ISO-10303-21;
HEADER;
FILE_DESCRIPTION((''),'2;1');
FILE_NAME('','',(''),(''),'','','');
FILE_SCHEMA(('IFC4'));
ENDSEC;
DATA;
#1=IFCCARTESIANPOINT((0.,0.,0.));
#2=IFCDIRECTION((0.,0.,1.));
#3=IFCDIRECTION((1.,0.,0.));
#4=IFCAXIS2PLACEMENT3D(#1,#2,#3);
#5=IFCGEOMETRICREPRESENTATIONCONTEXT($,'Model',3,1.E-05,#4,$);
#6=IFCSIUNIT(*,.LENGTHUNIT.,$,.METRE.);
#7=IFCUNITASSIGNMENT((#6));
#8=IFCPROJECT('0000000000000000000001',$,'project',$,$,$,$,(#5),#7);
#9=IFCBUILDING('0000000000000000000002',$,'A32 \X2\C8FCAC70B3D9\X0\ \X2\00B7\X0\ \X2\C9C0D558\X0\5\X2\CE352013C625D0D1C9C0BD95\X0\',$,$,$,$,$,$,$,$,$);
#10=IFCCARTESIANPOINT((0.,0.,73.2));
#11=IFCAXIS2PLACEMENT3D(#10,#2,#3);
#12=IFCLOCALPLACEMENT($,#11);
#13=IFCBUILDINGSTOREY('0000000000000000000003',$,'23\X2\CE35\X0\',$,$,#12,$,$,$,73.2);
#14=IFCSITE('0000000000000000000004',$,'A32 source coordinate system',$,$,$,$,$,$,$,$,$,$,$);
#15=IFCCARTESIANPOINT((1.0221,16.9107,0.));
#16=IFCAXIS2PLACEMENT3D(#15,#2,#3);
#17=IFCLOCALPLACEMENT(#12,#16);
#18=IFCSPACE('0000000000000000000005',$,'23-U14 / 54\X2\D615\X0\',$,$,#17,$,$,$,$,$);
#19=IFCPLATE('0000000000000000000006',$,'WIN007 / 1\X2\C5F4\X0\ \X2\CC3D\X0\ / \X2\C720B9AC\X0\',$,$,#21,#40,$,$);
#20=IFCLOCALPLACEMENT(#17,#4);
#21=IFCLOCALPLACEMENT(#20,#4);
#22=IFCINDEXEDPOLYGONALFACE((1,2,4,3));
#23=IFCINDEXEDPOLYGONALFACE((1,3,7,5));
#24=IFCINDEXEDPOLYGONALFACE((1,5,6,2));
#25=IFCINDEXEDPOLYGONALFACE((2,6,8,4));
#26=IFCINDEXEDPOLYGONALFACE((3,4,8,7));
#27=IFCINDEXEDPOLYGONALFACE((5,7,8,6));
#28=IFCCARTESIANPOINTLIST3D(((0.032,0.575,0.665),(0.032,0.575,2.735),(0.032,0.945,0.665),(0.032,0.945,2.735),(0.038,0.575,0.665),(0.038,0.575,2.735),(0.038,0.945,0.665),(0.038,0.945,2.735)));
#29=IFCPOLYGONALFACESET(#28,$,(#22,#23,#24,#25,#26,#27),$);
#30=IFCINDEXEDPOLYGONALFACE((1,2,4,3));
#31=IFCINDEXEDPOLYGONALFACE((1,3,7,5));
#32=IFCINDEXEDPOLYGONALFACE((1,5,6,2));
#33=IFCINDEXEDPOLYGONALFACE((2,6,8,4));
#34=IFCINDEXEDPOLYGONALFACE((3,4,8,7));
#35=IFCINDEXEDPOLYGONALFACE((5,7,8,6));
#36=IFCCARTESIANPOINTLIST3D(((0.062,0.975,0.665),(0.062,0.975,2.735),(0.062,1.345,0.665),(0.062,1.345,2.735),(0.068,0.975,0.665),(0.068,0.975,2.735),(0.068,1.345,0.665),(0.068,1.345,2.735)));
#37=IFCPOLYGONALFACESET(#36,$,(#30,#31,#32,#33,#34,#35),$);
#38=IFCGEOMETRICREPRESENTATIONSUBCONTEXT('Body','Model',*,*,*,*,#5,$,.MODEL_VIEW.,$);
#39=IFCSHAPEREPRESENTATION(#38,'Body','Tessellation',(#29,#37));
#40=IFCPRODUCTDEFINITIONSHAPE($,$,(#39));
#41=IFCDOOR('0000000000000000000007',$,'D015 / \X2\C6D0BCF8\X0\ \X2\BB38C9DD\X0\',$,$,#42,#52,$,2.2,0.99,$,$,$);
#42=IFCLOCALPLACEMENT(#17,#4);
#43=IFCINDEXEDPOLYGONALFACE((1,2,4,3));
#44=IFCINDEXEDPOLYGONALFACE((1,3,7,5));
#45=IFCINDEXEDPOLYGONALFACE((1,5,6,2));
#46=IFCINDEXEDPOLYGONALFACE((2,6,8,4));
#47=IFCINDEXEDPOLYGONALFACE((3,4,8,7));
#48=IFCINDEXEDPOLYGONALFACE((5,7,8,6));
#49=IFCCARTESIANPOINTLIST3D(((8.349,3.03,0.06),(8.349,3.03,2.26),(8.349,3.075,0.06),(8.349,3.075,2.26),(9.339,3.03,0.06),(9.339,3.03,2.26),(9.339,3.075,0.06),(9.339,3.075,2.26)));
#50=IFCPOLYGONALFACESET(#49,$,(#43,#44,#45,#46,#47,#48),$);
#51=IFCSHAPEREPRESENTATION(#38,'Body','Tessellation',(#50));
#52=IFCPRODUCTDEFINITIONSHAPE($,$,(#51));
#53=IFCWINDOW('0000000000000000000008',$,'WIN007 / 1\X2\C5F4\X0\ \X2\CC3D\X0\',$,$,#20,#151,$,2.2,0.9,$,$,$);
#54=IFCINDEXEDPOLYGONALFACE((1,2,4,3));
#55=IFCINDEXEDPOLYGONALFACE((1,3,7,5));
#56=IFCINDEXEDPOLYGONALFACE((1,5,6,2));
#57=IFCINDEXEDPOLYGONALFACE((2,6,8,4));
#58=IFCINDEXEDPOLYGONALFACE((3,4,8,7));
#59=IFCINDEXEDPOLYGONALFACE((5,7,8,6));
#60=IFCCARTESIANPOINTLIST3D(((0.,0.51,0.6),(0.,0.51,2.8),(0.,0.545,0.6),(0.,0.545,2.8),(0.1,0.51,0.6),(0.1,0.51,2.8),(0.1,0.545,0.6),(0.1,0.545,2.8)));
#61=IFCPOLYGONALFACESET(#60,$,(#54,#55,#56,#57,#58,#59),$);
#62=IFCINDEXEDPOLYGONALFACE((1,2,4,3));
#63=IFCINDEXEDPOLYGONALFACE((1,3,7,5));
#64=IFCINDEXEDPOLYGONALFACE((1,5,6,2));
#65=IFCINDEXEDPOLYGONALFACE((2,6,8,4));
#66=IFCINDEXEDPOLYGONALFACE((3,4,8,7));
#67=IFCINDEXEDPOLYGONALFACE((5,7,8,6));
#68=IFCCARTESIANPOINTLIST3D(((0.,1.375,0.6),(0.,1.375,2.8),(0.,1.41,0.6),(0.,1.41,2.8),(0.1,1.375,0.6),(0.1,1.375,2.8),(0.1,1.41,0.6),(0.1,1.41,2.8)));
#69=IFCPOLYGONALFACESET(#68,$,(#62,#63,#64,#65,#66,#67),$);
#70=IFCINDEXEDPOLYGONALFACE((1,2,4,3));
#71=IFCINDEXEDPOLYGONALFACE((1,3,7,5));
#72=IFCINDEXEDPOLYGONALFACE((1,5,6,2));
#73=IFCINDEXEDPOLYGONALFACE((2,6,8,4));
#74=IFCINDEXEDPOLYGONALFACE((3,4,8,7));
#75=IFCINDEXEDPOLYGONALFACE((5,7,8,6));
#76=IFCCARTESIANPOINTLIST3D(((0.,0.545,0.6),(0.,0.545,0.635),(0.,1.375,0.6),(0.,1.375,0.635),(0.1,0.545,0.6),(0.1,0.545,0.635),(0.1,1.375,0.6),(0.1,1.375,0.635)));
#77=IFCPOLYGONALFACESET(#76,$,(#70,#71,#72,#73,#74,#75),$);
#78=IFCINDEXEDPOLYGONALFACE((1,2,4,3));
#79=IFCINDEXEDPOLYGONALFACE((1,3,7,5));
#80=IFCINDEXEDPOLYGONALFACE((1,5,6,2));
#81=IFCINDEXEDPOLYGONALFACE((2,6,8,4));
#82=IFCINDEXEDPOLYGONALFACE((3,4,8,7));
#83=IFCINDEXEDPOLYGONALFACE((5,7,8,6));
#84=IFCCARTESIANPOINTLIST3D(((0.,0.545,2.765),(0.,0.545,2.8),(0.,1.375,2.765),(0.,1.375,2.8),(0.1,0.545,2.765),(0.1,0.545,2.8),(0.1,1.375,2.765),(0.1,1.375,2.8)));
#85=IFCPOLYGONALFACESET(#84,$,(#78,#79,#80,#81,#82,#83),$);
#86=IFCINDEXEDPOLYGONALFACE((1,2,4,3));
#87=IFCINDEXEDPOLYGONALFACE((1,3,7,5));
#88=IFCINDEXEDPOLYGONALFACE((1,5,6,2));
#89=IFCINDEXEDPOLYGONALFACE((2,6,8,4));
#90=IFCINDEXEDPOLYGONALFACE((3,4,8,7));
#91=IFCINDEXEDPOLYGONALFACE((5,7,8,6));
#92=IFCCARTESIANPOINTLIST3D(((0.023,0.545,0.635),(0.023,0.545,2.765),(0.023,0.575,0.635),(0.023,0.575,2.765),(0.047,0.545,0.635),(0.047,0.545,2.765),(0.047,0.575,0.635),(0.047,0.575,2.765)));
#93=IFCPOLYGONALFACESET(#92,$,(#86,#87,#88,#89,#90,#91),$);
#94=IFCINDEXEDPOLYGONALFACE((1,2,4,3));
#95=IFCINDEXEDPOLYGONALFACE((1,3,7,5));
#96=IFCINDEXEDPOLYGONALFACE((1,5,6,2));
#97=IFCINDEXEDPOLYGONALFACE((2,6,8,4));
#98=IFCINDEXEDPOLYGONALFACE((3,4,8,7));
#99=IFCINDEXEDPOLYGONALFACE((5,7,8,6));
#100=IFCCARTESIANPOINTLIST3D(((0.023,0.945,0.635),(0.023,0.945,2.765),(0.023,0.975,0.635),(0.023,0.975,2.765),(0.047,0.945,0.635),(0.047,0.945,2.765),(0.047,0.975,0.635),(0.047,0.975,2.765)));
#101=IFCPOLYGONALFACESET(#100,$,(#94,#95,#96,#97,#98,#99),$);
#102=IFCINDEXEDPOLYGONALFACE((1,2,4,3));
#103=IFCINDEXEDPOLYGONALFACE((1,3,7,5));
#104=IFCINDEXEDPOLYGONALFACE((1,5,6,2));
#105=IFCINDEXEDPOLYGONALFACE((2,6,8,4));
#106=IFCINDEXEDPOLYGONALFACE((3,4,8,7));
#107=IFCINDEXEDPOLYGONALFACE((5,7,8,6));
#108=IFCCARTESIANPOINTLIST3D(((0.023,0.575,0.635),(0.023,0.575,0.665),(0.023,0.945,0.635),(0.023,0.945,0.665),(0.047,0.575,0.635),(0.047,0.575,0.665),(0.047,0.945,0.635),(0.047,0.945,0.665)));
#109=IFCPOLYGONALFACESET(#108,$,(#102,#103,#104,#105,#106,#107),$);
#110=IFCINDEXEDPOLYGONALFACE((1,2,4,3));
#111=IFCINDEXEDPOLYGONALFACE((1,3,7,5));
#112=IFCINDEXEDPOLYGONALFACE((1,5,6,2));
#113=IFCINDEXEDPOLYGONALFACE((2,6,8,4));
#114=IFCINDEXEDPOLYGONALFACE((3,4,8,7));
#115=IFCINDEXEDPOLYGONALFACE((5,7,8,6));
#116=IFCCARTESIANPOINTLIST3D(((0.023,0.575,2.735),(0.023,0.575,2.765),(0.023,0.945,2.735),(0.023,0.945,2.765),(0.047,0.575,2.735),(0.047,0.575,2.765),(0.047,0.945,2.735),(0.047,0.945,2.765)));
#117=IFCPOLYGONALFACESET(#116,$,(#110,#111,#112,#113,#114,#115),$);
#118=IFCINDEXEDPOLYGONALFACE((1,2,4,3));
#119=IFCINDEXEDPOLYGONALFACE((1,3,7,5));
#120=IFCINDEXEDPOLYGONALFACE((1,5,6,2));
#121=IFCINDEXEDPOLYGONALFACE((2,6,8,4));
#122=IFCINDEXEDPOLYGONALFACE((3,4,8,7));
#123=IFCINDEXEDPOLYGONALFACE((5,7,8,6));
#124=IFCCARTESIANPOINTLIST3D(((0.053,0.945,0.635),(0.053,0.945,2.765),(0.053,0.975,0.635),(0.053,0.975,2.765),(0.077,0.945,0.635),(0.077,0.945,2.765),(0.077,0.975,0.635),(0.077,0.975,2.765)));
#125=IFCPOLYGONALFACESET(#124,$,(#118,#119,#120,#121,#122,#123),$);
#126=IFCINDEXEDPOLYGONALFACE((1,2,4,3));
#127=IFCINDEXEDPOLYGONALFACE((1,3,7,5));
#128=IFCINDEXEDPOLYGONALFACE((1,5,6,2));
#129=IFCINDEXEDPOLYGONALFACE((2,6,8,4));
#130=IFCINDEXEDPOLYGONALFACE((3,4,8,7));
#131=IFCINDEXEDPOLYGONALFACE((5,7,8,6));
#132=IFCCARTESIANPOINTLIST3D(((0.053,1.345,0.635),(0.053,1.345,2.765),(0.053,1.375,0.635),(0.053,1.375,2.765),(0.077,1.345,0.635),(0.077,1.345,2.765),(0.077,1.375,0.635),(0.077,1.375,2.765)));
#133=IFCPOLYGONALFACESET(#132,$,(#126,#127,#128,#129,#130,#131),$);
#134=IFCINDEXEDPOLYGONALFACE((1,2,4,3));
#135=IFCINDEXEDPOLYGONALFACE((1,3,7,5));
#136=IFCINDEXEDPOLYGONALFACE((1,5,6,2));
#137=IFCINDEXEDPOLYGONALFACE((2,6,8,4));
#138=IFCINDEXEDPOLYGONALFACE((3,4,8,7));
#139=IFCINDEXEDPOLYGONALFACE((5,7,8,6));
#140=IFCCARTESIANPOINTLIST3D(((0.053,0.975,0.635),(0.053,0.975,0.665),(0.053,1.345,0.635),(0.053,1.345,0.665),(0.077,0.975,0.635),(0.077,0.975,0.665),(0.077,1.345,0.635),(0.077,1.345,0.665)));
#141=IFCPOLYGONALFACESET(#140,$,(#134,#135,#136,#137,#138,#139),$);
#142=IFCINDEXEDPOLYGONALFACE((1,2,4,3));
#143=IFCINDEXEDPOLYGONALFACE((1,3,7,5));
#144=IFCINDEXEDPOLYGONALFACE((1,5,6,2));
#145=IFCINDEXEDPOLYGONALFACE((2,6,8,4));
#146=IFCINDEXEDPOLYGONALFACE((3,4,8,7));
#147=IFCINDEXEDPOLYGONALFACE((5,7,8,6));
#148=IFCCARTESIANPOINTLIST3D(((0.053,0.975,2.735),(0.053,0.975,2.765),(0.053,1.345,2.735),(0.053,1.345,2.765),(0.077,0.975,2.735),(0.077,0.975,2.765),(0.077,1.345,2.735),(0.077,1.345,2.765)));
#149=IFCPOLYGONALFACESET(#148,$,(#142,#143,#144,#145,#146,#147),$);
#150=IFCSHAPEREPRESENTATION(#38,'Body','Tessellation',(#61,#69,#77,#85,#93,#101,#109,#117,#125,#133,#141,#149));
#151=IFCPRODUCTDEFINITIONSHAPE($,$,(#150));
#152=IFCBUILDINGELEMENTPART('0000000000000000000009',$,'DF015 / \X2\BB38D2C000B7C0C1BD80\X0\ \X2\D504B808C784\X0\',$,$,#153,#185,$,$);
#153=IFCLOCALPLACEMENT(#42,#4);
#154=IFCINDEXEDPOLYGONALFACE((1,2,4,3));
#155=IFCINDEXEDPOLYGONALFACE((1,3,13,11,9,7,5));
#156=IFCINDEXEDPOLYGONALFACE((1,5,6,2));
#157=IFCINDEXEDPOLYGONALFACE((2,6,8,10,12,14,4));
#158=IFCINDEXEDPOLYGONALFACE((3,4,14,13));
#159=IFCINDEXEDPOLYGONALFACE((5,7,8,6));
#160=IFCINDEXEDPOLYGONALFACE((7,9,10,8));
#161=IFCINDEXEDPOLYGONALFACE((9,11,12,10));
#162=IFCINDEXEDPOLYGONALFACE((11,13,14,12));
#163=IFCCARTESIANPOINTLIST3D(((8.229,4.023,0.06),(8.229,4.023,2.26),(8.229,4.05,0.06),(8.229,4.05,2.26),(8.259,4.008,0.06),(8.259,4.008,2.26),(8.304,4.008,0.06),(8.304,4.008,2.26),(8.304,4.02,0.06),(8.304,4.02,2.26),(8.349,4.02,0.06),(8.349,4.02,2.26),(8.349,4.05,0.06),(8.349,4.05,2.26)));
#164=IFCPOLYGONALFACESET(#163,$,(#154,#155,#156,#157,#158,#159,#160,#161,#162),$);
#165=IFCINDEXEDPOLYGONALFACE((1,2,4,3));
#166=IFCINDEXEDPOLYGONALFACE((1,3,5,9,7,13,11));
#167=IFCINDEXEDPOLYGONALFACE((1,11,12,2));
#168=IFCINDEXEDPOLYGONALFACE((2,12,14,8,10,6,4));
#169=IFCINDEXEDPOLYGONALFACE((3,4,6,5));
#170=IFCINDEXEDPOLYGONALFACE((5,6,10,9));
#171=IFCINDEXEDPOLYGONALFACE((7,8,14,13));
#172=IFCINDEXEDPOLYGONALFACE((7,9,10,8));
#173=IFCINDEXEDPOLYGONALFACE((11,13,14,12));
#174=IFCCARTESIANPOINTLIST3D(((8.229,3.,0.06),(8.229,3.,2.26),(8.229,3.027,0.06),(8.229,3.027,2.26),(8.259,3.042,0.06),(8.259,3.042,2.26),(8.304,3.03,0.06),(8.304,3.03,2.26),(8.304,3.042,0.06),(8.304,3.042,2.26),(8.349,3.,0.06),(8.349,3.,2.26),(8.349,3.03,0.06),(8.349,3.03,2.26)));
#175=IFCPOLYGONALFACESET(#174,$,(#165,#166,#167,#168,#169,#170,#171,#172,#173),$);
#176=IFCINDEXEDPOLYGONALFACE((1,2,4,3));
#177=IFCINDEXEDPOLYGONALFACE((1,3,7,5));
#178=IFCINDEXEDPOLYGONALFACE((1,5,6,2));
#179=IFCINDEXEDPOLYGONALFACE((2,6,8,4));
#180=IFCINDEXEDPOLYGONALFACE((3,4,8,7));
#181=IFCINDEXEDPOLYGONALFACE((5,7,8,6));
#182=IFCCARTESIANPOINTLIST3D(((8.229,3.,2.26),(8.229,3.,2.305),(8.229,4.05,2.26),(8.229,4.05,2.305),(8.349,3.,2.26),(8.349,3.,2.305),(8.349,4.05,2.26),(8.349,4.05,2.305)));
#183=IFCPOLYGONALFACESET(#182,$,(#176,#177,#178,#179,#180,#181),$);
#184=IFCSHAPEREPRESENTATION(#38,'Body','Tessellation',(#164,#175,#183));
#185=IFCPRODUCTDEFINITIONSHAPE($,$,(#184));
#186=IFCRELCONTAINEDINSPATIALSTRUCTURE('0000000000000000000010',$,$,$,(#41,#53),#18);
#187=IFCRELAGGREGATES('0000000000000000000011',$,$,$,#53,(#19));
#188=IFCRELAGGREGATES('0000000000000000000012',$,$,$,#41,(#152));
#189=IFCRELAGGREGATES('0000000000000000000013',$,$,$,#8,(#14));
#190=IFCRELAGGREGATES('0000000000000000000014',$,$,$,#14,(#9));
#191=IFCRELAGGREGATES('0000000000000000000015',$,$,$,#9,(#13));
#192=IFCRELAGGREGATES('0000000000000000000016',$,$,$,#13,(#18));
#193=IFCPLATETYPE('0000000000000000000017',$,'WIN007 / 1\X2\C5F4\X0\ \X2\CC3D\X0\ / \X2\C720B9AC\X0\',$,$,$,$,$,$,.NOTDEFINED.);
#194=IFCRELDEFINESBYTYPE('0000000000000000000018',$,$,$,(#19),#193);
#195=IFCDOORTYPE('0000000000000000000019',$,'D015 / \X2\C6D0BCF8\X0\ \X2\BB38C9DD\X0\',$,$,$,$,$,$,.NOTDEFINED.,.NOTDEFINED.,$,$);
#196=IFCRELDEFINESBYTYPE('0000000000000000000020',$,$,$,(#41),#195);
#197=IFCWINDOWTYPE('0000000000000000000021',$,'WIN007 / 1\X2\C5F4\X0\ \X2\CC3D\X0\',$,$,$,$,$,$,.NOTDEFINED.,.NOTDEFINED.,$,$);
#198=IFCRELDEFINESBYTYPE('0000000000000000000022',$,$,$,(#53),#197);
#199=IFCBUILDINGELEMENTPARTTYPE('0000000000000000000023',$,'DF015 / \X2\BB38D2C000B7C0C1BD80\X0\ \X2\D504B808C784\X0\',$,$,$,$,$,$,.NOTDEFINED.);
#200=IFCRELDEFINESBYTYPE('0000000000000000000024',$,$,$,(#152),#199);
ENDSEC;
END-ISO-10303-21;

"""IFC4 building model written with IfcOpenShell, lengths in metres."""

from ifc_helpers import new_model, si_unit, frame, origin, origin_with_axes, place, context, subcontext, project, spatial, polyline, outline, extrude, source, transform, mapped, type_object, type_shapes, element, aggregate, save


model = new_model("IFC4")

# Units and contexts
model_context = context("Model", 3, precision=1e-05, world=origin_with_axes())
body_context = subcontext(model_context, "Body", "Model", "MODEL_VIEW")
ifc_project = project(units=[si_unit("LENGTHUNIT", "METRE")], contexts=[model_context])

# Plate
plate_type_1 = type_object("IfcPlateType", Name="WIN007 / 1열 창 / 유리", PredefinedType="NOTDEFINED")
shared_shape_1 = source(origin(), body_context, "Body", "SweptSolid", [
    extrude(outline(polyline([(0.032, 0.575), (0.032, 0.945), (0.038, 0.945), (0.038, 0.575), (0.032, 0.575)])), frame((0.0, 0.0, 0.665)), (0.0, 0.0, 1.0), 2.07),
    extrude(outline(polyline([(0.062, 0.975), (0.062, 1.345), (0.068, 1.345), (0.068, 0.975), (0.062, 0.975)])), frame((0.0, 0.0, 0.665)), (0.0, 0.0, 1.0), 2.07),
])
type_shapes(plate_type_1, [shared_shape_1])
storey_placement = place(None, frame((0.0, 0.0, 73.2), z_axis=(0.0, 0.0, 1.0), x_axis=(1.0, 0.0, 0.0)))
space_placement = place(storey_placement, frame((1.0221, 16.9107, 0.0), z_axis=(0.0, 0.0, 1.0), x_axis=(1.0, 0.0, 0.0)))
window_1_placement = place(space_placement, origin_with_axes())
plate_1_placement = place(window_1_placement, origin_with_axes())
plate_1 = element("IfcPlate", 1, at=plate_1_placement, type_object=plate_type_1, Name="WIN007 / 1열 창 / 유리", context=body_context, shape_type="MappedRepresentation", body=[
    mapped(shared_shape_1, transform((0.0, 0.0, 0.0), scale=1.0)),
])

# Site, building, storey, space
site = spatial("IfcSite", under=ifc_project, Name="A32 source coordinate system")
building = spatial("IfcBuilding", under=site, Name="A32 주거동 · 지하5층–옥탑지붕")
storey = spatial("IfcBuildingStorey", under=building, at=storey_placement, Name="23층", Elevation=73.2)
space = spatial("IfcSpace", under=storey, at=space_placement, Name="23-U14 / 54형")

# Door
door_type_1 = type_object("IfcDoorType", Name="D015 / 원본 문짝", OperationType="NOTDEFINED", PredefinedType="NOTDEFINED")
shared_shape_2 = source(origin(), body_context, "Body", "SweptSolid", [
    extrude(outline(polyline([(9.339, 3.075), (9.339, 3.03), (8.349, 3.03), (8.349, 3.075), (9.339, 3.075)])), frame((0.0, 0.0, 0.06)), (0.0, 0.0, 1.0), 2.2),
])
type_shapes(door_type_1, [shared_shape_2])
door_1_placement = place(space_placement, origin_with_axes())
door_1 = element("IfcDoor", 2, at=door_1_placement, inside=space, type_object=door_type_1, Name="D015 / 원본 문짝", OverallHeight=2.2, OverallWidth=0.99, context=body_context, shape_type="MappedRepresentation", body=[
    mapped(shared_shape_2, transform((0.0, 0.0, 0.0), scale=1.0)),
])

# Window
window_type_1 = type_object("IfcWindowType", Name="WIN007 / 1열 창", PartitioningType="NOTDEFINED", PredefinedType="NOTDEFINED")
shared_shape_3 = source(origin(), body_context, "Body", "SweptSolid", [
    extrude(outline(polyline([(0.0, 0.51), (0.0, 0.545), (0.1, 0.545), (0.1, 0.51), (0.0, 0.51)])), frame((0.0, 0.0, 0.6)), (0.0, 0.0, 1.0), 2.2),
    extrude(outline(polyline([(0.0, 1.375), (0.0, 1.41), (0.1, 1.41), (0.1, 1.375), (0.0, 1.375)])), frame((0.0, 0.0, 0.6)), (0.0, 0.0, 1.0), 2.2),
    extrude(outline(polyline([(0.0, 0.545), (0.0, 1.375), (0.1, 1.375), (0.1, 0.545), (0.0, 0.545)])), frame((0.0, 0.0, 0.6)), (0.0, 0.0, 1.0), 0.035),
    extrude(outline(polyline([(0.0, 0.545), (0.0, 1.375), (0.1, 1.375), (0.1, 0.545), (0.0, 0.545)])), frame((0.0, 0.0, 2.765)), (0.0, 0.0, 1.0), 0.035),
    extrude(outline(polyline([(0.023, 0.545), (0.023, 0.575), (0.047, 0.575), (0.047, 0.545), (0.023, 0.545)])), frame((0.0, 0.0, 0.635)), (0.0, 0.0, 1.0), 2.13),
    extrude(outline(polyline([(0.023, 0.945), (0.023, 0.975), (0.047, 0.975), (0.047, 0.945), (0.023, 0.945)])), frame((0.0, 0.0, 0.635)), (0.0, 0.0, 1.0), 2.13),
    extrude(outline(polyline([(0.023, 0.575), (0.023, 0.945), (0.047, 0.945), (0.047, 0.575), (0.023, 0.575)])), frame((0.0, 0.0, 0.635)), (0.0, 0.0, 1.0), 0.03),
    extrude(outline(polyline([(0.023, 0.575), (0.023, 0.945), (0.047, 0.945), (0.047, 0.575), (0.023, 0.575)])), frame((0.0, 0.0, 2.735)), (0.0, 0.0, 1.0), 0.03),
    extrude(outline(polyline([(0.053, 0.945), (0.053, 0.975), (0.077, 0.975), (0.077, 0.945), (0.053, 0.945)])), frame((0.0, 0.0, 0.635)), (0.0, 0.0, 1.0), 2.13),
    extrude(outline(polyline([(0.053, 1.345), (0.053, 1.375), (0.077, 1.375), (0.077, 1.345), (0.053, 1.345)])), frame((0.0, 0.0, 0.635)), (0.0, 0.0, 1.0), 2.13),
    extrude(outline(polyline([(0.053, 0.975), (0.053, 1.345), (0.077, 1.345), (0.077, 0.975), (0.053, 0.975)])), frame((0.0, 0.0, 0.635)), (0.0, 0.0, 1.0), 0.03),
    extrude(outline(polyline([(0.053, 0.975), (0.053, 1.345), (0.077, 1.345), (0.077, 0.975), (0.053, 0.975)])), frame((0.0, 0.0, 2.735)), (0.0, 0.0, 1.0), 0.03),
])
type_shapes(window_type_1, [shared_shape_3])
window_1 = element("IfcWindow", 3, at=window_1_placement, inside=space, type_object=window_type_1, Name="WIN007 / 1열 창", OverallHeight=2.2, OverallWidth=0.9, context=body_context, shape_type="MappedRepresentation", body=[
    mapped(shared_shape_3, transform((0.0, 0.0, 0.0), scale=1.0)),
])
aggregate(window_1, [plate_1])

# Building element part
building_element_part_type_1 = type_object("IfcBuildingElementPartType", Name="DF015 / 문틀·상부 프레임", PredefinedType="NOTDEFINED")
shared_shape_4 = source(origin(), body_context, "Body", "SweptSolid", [
    extrude(outline(polyline([(8.349, 4.02), (8.304, 4.02), (8.304, 4.008), (8.259, 4.008), (8.229, 4.023), (8.229, 4.05), (8.349, 4.05), (8.349, 4.02)])), frame((0.0, 0.0, 0.06)), (0.0, 0.0, 1.0), 2.2),
    extrude(outline(polyline([(8.229, 3.0), (8.229, 3.027), (8.259, 3.042), (8.304, 3.042), (8.304, 3.03), (8.349, 3.03), (8.349, 3.0), (8.229, 3.0)])), frame((0.0, 0.0, 0.06)), (0.0, 0.0, 1.0), 2.2),
    extrude(outline(polyline([(8.229, 3.0), (8.229, 4.05), (8.349, 4.05), (8.349, 3.0), (8.229, 3.0)])), frame((0.0, 0.0, 2.26)), (0.0, 0.0, 1.0), 0.045),
])
type_shapes(building_element_part_type_1, [shared_shape_4])
building_element_part_1_placement = place(door_1_placement, origin_with_axes())
building_element_part_1 = element("IfcBuildingElementPart", 4, at=building_element_part_1_placement, type_object=building_element_part_type_1, Name="DF015 / 문틀·상부 프레임", context=body_context, shape_type="MappedRepresentation", body=[
    mapped(shared_shape_4, transform((0.0, 0.0, 0.0), scale=1.0)),
])
aggregate(door_1, [building_element_part_1])

save(model, "model.ifc")
